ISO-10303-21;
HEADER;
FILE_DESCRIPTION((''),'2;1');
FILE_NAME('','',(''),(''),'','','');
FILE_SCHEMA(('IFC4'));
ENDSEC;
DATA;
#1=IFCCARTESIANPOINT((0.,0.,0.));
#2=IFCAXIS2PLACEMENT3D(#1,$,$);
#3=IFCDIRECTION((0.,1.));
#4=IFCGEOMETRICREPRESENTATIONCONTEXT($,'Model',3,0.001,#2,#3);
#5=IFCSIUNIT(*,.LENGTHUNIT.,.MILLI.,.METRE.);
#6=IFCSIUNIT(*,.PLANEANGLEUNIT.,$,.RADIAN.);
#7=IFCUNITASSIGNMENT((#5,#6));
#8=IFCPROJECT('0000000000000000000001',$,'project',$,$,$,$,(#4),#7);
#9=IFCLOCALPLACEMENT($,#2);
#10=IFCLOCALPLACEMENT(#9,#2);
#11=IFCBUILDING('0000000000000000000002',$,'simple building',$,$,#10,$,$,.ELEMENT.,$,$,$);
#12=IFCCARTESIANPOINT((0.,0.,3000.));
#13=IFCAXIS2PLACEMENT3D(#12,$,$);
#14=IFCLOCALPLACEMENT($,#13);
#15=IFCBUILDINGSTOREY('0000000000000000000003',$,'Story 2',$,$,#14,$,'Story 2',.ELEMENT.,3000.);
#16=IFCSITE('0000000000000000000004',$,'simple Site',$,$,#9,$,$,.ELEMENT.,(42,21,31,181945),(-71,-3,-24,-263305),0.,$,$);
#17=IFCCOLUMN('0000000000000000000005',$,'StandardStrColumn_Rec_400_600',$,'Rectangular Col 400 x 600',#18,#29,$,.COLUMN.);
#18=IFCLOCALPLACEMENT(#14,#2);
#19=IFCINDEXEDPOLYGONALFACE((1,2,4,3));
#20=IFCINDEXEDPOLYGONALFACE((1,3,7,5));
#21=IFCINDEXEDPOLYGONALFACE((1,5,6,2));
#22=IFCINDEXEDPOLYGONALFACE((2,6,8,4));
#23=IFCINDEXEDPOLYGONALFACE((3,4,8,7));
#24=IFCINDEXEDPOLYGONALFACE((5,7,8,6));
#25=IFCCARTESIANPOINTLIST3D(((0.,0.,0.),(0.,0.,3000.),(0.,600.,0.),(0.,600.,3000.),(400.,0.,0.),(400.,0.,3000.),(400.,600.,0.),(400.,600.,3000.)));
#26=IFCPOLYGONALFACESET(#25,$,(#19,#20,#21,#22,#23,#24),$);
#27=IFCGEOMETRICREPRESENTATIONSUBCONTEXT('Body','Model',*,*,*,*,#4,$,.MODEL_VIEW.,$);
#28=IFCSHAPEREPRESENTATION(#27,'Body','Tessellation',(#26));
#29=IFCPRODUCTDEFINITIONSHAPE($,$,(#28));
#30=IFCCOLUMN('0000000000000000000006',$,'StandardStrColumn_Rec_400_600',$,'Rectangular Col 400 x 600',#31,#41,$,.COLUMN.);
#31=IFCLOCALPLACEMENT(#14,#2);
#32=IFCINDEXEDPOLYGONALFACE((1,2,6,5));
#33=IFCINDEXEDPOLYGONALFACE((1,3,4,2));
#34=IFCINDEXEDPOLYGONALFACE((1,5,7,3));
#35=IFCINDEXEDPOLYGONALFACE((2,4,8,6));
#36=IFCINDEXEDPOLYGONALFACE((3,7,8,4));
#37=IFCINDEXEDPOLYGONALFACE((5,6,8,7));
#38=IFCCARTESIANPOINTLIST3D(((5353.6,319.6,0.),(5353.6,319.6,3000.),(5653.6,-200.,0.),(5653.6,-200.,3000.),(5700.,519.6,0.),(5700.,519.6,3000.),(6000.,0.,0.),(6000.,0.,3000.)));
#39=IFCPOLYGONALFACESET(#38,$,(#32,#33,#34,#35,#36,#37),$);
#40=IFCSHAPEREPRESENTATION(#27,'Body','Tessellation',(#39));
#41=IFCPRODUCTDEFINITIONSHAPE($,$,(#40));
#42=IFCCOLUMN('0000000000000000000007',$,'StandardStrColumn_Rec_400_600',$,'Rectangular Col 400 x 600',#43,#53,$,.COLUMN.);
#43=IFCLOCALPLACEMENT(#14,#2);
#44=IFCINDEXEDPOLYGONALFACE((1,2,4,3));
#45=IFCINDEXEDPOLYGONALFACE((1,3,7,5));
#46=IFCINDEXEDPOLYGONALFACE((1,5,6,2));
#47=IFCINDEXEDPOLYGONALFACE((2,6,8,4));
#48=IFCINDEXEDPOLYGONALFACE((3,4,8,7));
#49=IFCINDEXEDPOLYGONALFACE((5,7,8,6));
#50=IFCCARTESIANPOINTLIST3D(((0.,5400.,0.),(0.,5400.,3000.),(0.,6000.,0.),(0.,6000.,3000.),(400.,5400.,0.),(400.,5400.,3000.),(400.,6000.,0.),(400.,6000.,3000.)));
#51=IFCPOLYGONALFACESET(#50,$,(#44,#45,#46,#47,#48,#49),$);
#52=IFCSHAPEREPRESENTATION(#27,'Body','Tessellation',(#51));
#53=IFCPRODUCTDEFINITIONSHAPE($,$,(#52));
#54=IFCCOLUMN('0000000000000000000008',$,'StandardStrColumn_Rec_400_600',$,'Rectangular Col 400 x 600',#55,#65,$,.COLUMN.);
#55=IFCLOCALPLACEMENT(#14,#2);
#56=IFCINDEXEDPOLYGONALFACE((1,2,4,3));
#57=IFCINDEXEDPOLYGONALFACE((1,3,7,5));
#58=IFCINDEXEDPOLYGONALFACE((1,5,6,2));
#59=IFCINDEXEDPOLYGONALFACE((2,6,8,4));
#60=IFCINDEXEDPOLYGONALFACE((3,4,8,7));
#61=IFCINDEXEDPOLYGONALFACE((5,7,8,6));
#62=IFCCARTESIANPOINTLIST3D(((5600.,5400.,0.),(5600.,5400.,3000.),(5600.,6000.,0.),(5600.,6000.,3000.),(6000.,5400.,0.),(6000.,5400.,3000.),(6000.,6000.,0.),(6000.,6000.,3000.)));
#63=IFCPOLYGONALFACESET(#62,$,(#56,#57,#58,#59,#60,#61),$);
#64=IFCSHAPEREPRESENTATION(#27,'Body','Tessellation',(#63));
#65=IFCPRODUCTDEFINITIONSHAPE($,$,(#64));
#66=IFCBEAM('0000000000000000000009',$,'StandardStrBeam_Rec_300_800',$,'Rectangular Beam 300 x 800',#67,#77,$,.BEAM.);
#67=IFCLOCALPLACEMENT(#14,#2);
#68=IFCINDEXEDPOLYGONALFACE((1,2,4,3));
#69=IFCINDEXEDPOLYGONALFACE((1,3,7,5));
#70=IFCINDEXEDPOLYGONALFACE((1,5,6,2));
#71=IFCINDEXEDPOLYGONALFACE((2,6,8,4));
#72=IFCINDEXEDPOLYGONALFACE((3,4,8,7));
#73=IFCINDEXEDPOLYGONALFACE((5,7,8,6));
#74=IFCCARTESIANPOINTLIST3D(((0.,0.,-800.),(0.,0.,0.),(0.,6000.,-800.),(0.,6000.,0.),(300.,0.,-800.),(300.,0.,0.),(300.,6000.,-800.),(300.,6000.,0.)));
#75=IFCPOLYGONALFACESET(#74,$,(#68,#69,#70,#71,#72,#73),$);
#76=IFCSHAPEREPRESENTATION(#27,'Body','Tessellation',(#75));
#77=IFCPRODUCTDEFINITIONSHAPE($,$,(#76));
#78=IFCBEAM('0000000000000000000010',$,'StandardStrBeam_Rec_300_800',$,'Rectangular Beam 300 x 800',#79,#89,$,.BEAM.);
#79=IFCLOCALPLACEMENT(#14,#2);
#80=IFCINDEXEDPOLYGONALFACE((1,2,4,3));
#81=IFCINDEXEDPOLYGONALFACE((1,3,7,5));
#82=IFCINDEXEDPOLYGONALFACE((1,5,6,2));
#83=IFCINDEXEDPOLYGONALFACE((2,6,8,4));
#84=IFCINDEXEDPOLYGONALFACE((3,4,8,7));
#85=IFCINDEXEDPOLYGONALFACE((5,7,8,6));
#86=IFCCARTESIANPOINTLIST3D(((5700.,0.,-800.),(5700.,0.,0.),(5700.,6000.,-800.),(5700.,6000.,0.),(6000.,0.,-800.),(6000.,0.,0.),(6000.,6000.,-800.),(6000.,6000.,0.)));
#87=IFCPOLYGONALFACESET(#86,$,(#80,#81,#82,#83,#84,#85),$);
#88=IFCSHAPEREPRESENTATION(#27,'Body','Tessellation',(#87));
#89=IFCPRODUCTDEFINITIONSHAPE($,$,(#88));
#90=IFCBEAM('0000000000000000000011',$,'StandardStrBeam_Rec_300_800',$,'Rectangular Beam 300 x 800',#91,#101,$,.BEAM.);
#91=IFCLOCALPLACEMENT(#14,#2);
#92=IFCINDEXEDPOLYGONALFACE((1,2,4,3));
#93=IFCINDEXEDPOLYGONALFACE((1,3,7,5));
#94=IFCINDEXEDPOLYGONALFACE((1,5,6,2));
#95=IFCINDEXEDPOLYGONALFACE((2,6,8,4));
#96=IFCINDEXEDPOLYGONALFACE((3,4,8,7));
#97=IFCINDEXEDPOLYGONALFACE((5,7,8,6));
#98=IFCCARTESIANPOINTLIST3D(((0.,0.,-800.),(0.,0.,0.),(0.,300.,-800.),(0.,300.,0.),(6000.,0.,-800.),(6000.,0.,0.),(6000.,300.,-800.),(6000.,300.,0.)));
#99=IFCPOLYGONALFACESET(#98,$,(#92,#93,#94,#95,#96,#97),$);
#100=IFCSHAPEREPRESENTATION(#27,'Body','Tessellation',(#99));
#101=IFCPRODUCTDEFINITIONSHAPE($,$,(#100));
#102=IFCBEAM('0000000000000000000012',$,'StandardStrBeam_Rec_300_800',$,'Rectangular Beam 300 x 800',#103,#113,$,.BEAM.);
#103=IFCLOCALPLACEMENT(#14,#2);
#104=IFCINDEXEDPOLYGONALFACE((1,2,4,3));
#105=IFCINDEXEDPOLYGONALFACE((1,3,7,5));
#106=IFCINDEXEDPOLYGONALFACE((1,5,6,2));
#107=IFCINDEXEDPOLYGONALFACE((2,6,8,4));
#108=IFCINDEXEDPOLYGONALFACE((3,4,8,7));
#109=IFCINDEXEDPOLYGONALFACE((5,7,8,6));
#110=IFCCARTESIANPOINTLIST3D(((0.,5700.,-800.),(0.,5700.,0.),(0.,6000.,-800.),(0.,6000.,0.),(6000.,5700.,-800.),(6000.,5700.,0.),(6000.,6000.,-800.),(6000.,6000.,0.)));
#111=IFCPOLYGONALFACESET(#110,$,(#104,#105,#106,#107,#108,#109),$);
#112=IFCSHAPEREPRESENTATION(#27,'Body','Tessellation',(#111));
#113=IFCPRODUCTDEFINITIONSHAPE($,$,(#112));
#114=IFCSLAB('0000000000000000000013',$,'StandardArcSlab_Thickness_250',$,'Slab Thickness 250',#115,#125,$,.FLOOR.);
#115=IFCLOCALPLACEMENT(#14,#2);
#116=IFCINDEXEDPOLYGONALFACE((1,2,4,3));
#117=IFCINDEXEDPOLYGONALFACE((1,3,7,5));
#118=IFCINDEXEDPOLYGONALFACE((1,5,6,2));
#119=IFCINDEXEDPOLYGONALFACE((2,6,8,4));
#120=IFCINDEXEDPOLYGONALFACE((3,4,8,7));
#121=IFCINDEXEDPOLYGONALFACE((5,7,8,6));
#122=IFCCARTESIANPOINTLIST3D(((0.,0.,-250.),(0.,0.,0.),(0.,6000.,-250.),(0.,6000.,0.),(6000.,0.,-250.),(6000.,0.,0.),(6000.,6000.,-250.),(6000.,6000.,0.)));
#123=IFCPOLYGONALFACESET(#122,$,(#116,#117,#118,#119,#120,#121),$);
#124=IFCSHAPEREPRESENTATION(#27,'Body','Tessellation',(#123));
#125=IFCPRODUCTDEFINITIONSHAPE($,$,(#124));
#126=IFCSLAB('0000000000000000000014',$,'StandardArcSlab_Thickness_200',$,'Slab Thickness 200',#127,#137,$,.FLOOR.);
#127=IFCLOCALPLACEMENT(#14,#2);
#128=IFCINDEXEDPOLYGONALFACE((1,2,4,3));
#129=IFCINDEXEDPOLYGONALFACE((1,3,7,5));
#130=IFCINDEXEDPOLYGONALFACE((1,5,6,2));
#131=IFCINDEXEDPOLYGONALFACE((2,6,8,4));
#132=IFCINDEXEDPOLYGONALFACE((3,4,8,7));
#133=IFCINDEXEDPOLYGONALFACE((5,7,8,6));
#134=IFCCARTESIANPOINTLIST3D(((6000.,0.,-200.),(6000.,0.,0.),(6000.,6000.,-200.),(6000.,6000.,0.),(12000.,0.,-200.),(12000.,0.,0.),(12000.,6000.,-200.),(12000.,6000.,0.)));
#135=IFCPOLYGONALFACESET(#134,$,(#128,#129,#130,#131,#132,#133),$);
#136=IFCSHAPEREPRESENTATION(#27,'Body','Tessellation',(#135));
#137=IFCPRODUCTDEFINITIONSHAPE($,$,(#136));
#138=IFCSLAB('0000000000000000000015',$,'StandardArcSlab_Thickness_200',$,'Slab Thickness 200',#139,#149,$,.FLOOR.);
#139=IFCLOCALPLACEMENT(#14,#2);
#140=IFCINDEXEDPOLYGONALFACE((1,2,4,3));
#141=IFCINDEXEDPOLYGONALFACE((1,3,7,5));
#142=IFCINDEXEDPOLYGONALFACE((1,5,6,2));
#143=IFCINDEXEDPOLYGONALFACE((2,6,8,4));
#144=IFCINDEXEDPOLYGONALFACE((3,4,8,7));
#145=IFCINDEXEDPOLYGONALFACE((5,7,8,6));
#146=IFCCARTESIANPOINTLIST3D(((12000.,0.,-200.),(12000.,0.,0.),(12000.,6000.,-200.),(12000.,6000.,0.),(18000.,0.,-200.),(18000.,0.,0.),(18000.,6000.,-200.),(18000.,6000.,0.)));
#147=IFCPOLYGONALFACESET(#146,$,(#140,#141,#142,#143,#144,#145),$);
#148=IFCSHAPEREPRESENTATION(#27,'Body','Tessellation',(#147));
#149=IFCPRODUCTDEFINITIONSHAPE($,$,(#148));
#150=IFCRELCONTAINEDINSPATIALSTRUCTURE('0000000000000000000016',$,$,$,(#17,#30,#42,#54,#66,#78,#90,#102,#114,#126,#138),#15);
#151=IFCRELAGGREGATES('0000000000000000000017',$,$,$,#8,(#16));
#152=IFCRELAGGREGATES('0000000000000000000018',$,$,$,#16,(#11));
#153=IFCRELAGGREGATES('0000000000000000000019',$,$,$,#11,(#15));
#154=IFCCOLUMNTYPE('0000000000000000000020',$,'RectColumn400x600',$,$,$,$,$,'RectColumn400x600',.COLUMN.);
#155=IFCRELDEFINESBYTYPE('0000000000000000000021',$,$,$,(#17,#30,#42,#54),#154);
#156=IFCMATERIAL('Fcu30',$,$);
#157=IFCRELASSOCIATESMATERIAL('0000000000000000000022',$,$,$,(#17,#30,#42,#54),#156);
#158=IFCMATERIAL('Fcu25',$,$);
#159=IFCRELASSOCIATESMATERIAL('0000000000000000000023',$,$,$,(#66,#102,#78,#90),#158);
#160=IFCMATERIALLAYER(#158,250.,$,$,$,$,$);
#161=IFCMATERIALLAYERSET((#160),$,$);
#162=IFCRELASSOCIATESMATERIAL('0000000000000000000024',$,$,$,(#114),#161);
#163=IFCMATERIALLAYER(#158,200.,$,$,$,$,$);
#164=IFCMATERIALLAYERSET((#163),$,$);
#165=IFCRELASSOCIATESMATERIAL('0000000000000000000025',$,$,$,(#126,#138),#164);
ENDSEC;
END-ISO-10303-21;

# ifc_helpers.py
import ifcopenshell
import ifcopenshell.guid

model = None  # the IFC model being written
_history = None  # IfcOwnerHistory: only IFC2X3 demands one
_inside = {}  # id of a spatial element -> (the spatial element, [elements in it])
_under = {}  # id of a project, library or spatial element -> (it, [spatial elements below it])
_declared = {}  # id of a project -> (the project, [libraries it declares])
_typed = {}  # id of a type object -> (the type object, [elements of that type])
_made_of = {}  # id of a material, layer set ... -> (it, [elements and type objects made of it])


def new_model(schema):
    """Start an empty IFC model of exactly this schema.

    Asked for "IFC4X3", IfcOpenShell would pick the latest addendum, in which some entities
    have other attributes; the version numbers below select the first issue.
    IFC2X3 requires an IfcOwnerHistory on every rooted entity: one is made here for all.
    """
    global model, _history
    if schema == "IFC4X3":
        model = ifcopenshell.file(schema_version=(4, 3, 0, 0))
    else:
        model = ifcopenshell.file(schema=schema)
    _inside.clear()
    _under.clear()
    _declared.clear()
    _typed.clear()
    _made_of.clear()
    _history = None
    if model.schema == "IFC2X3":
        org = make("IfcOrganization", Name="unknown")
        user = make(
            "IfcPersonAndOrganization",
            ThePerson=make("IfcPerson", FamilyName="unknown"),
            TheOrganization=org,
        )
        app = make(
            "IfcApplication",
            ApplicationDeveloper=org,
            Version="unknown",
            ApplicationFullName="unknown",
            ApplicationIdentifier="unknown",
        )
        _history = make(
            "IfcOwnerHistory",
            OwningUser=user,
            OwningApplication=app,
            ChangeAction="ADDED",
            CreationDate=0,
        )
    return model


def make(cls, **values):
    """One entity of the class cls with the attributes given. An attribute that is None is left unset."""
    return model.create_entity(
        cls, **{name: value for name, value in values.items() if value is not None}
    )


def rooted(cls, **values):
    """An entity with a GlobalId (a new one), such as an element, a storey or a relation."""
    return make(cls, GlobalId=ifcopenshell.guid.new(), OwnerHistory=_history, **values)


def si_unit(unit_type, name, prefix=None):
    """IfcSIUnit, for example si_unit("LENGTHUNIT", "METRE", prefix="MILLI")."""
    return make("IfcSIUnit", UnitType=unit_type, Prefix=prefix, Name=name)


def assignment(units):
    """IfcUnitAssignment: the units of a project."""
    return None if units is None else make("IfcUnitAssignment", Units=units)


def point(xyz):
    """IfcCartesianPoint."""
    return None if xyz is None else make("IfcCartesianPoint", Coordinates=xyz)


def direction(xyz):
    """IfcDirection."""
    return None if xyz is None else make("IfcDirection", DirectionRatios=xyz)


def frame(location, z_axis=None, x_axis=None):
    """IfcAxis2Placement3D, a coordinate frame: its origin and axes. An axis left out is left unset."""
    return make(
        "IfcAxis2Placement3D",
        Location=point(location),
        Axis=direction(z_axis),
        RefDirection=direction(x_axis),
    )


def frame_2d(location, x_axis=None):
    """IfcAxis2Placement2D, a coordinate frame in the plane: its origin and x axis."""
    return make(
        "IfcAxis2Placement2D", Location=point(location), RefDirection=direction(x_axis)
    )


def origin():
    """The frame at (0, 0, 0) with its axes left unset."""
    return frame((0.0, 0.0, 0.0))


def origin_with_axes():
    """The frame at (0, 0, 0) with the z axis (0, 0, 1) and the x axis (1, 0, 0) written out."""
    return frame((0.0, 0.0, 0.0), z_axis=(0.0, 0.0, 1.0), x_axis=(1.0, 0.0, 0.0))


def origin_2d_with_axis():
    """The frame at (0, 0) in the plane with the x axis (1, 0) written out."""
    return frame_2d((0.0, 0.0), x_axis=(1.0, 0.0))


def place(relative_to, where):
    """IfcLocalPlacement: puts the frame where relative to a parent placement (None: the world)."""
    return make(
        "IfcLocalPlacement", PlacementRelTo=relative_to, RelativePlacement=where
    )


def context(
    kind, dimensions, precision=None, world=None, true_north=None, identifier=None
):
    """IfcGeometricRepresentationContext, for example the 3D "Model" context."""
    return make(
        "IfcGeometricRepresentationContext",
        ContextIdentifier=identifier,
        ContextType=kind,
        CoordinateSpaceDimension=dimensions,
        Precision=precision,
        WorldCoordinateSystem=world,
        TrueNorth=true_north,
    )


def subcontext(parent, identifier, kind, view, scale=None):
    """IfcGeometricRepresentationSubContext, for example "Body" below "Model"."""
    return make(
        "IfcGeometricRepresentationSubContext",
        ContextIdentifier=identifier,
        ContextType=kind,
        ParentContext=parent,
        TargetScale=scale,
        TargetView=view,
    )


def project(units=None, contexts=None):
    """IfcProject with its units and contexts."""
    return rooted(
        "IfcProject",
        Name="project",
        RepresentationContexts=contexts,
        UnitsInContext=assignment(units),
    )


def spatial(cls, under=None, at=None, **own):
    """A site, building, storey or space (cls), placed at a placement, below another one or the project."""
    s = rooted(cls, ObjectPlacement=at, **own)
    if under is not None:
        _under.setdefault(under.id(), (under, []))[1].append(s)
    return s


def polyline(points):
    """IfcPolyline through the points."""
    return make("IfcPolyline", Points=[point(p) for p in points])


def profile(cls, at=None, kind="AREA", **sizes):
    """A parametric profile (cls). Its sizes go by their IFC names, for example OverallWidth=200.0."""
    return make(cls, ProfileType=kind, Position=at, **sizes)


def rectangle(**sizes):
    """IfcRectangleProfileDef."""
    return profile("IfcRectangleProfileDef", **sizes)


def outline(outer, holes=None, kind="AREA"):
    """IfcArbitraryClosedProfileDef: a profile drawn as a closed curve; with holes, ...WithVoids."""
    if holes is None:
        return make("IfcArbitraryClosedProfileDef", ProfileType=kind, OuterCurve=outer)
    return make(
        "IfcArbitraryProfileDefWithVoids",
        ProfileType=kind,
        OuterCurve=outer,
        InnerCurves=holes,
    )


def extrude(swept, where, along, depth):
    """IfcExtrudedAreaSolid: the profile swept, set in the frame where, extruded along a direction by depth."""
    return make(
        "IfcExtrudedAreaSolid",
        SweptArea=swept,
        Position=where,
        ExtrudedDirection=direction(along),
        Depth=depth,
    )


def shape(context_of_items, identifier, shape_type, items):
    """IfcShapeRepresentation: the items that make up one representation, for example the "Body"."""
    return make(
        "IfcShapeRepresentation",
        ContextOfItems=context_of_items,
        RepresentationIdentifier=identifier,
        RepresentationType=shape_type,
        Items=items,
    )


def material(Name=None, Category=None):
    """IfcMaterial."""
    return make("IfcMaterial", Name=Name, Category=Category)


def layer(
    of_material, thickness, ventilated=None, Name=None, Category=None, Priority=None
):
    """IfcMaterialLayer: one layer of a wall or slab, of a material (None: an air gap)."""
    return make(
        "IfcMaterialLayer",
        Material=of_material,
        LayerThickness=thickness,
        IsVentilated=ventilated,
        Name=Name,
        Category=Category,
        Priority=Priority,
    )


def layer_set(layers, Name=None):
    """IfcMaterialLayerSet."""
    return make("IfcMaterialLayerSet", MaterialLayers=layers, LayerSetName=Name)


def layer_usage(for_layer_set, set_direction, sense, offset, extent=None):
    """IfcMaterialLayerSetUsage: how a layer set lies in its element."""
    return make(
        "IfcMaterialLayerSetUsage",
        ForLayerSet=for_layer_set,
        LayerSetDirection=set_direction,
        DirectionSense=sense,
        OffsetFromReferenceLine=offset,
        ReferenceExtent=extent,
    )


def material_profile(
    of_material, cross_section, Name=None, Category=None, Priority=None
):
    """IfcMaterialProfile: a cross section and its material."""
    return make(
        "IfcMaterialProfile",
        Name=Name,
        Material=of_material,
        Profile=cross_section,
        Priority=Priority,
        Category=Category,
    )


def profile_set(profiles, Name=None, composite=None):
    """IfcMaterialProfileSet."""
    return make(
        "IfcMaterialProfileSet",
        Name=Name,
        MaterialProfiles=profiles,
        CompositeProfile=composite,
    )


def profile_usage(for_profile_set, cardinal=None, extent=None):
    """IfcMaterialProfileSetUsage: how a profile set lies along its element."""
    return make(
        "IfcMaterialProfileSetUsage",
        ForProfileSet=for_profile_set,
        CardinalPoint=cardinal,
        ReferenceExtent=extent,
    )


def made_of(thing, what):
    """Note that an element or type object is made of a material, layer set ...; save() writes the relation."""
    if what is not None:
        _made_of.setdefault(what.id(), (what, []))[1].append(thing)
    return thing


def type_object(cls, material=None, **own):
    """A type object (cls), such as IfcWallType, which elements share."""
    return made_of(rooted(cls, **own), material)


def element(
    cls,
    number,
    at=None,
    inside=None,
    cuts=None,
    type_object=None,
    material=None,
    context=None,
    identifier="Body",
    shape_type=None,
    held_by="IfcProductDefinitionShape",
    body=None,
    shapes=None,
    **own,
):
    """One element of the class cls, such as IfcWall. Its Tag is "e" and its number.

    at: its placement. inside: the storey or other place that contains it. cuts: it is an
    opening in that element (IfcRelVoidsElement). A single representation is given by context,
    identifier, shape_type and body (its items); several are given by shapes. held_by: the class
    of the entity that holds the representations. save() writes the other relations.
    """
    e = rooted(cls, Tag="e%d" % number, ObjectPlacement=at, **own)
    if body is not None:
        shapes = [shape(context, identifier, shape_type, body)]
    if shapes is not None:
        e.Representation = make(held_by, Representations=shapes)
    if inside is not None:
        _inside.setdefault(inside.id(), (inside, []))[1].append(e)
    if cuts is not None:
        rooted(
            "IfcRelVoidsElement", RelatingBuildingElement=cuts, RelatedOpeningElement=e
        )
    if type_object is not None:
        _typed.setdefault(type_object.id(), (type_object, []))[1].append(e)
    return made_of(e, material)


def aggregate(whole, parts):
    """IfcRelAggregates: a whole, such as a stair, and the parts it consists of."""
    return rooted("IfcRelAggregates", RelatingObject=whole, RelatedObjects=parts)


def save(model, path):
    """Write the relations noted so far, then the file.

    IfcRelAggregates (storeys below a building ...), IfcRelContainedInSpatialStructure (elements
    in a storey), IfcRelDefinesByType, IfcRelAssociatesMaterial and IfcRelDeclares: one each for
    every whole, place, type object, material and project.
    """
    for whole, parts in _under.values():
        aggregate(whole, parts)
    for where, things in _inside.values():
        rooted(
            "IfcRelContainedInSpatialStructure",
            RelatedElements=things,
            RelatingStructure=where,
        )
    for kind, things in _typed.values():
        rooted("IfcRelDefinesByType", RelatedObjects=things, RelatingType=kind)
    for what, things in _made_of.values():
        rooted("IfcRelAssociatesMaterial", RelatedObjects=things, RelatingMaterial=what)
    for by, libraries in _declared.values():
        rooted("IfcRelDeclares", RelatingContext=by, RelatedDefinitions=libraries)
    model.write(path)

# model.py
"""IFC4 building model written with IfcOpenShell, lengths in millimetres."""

from ifc_helpers import new_model, si_unit, direction, frame, origin, origin_with_axes, origin_2d_with_axis, place, context, subcontext, project, spatial, polyline, rectangle, outline, extrude, material, layer, layer_set, layer_usage, material_profile, profile_set, profile_usage, type_object, element, save


model = new_model("IFC4")

# Units and contexts
model_context = context("Model", 3, precision=0.001, world=origin(), true_north=direction((0.0, 1.0)))
body_context = subcontext(model_context, "Body", "Model", "MODEL_VIEW")
ifc_project = project(units=[si_unit("LENGTHUNIT", "METRE", prefix="MILLI"), si_unit("PLANEANGLEUNIT", "RADIAN")], contexts=[model_context])

# Site, building, storey
site_placement = place(None, origin())
site = spatial("IfcSite", under=ifc_project, at=site_placement, Name="simple Site", CompositionType="ELEMENT", RefLatitude=(42, 21, 31, 181945), RefLongitude=(-71, -3, -24, -263305), RefElevation=0.0)
building_placement = place(site_placement, origin())
building = spatial("IfcBuilding", under=site, at=building_placement, Name="simple building", CompositionType="ELEMENT")
storey_placement = place(None, frame((0.0, 0.0, 3000.0)))
storey = spatial("IfcBuildingStorey", under=building, at=storey_placement, Name="Story 2", LongName="Story 2", CompositionType="ELEMENT", Elevation=3000.0)

# Columns
ifc_material_1 = material(Name="Fcu30")
ifc_material_profile_1 = material_profile(ifc_material_1, rectangle(XDim=400.0, YDim=600.0, at=origin_2d_with_axis()))
ifc_profile_set_1 = profile_set([ifc_material_profile_1])
ifc_profile_usage_1 = profile_usage(ifc_profile_set_1, cardinal=7)
column_type = type_object("IfcColumnType", Name="RectColumn400x600", ElementType="RectColumn400x600", PredefinedType="COLUMN")
column_1_placement = place(None, frame((200.0, 300.0, 3000.0), z_axis=(0.0, 0.0, 1.0), x_axis=(1.0, 0.0, 0.0)))
element("IfcColumn", 1, at=column_1_placement, inside=storey, type_object=column_type, material=ifc_profile_usage_1, Name="StandardStrColumn_Rec_400_600", ObjectType="Rectangular Col 400 x 600", PredefinedType="COLUMN", context=body_context, shape_type="SweptSolid", body=[
    extrude(rectangle(XDim=400.0, YDim=600.0, at=origin_2d_with_axis()), origin_with_axes(), (0.0, 0.0, 1.0), 3000.0),
])
ifc_profile_usage_2 = profile_usage(ifc_profile_set_1, cardinal=9)
column_2_placement = place(None, frame((5676.8, 159.8, 3000.0), z_axis=(0.0, 0.0, 1.0), x_axis=(0.866025, 0.5, 0.0)))
element("IfcColumn", 2, at=column_2_placement, inside=storey, type_object=column_type, material=ifc_profile_usage_2, Name="StandardStrColumn_Rec_400_600", ObjectType="Rectangular Col 400 x 600", PredefinedType="COLUMN", context=body_context, shape_type="SweptSolid", body=[
    extrude(rectangle(XDim=400.0, YDim=600.0, at=origin_2d_with_axis()), origin_with_axes(), (0.0, 0.0, 1.0), 3000.0),
])
ifc_profile_usage_3 = profile_usage(ifc_profile_set_1, cardinal=1)
column_3_placement = place(None, frame((200.0, 5700.0, 3000.0), z_axis=(0.0, 0.0, 1.0), x_axis=(1.0, 0.0, 0.0)))
element("IfcColumn", 3, at=column_3_placement, inside=storey, type_object=column_type, material=ifc_profile_usage_3, Name="StandardStrColumn_Rec_400_600", ObjectType="Rectangular Col 400 x 600", PredefinedType="COLUMN", context=body_context, shape_type="SweptSolid", body=[
    extrude(rectangle(XDim=400.0, YDim=600.0, at=origin_2d_with_axis()), origin_with_axes(), (0.0, 0.0, 1.0), 3000.0),
])
ifc_profile_usage_4 = profile_usage(ifc_profile_set_1, cardinal=3)
column_4_placement = place(None, frame((5800.0, 5700.0, 3000.0), z_axis=(0.0, 0.0, 1.0), x_axis=(1.0, 0.0, 0.0)))
element("IfcColumn", 4, at=column_4_placement, inside=storey, type_object=column_type, material=ifc_profile_usage_4, Name="StandardStrColumn_Rec_400_600", ObjectType="Rectangular Col 400 x 600", PredefinedType="COLUMN", context=body_context, shape_type="SweptSolid", body=[
    extrude(rectangle(XDim=400.0, YDim=600.0, at=origin_2d_with_axis()), origin_with_axes(), (0.0, 0.0, 1.0), 3000.0),
])

# Beams
ifc_material_2 = material(Name="Fcu25")
ifc_material_profile_2 = material_profile(ifc_material_2, rectangle(XDim=300.0, YDim=800.0, at=origin_2d_with_axis()))
ifc_profile_set_2 = profile_set([ifc_material_profile_2])
ifc_profile_usage_5 = profile_usage(ifc_profile_set_2, cardinal=7)
beam_1_placement = place(None, frame((150.0, 0.0, 2600.0), z_axis=(0.0, 1.0, 0.0), x_axis=(1.0, 0.0, 0.0)))
element("IfcBeam", 5, at=beam_1_placement, inside=storey, material=ifc_profile_usage_5, Name="StandardStrBeam_Rec_300_800", ObjectType="Rectangular Beam 300 x 800", PredefinedType="BEAM", context=body_context, shape_type="SweptSolid", body=[
    extrude(rectangle(XDim=300.0, YDim=800.0, at=origin_2d_with_axis()), origin_with_axes(), (0.0, 0.0, 1.0), 6000.0),
])
ifc_profile_usage_6 = profile_usage(ifc_profile_set_2, cardinal=9)
for number, where, z_axis, x_axis, name in (
    (6, (5850.0, 0.0, 2600.0), (0.0, 1.0, 0.0), (1.0, 0.0, 0.0), "StandardStrBeam_Rec_300_800"),
    (7, (0.0, 150.0, 2600.0), (1.0, 0.0, 0.0), (0.0, -1.0, 0.0), "StandardStrBeam_Rec_300_800"),
):
    element("IfcBeam", number, at=place(None, frame(where, z_axis=z_axis, x_axis=x_axis)), inside=storey, material=ifc_profile_usage_6, Name=name, ObjectType="Rectangular Beam 300 x 800", PredefinedType="BEAM", context=body_context, shape_type="SweptSolid", body=[
        extrude(rectangle(XDim=300.0, YDim=800.0, at=origin_2d_with_axis()), origin_with_axes(), (0.0, 0.0, 1.0), 6000.0),
    ])
beam_2_placement = place(None, frame((0.0, 5850.0, 2600.0), z_axis=(1.0, 0.0, 0.0), x_axis=(0.0, -1.0, 0.0)))
element("IfcBeam", 8, at=beam_2_placement, inside=storey, material=ifc_profile_usage_5, Name="StandardStrBeam_Rec_300_800", ObjectType="Rectangular Beam 300 x 800", PredefinedType="BEAM", context=body_context, shape_type="SweptSolid", body=[
    extrude(rectangle(XDim=300.0, YDim=800.0, at=origin_2d_with_axis()), origin_with_axes(), (0.0, 0.0, 1.0), 6000.0),
])

# Slabs
ifc_layer_1 = layer(ifc_material_2, 250.0)
ifc_layer_set_1 = layer_set([ifc_layer_1])
ifc_layer_usage_1 = layer_usage(ifc_layer_set_1, "AXIS3", "POSITIVE", -250.0)
slab_placement = place(None, frame((0.0, 0.0, 2750.0), z_axis=(0.0, 0.0, 1.0), x_axis=(1.0, 0.0, 0.0)))
element("IfcSlab", 9, at=slab_placement, inside=storey, material=ifc_layer_usage_1, Name="StandardArcSlab_Thickness_250", ObjectType="Slab Thickness 250", PredefinedType="FLOOR", context=body_context, shape_type="SweptSolid", body=[
    extrude(outline(polyline([(0.0, 0.0), (6000.0, 0.0), (6000.0, 6000.0), (0.0, 6000.0), (0.0, 0.0)])), origin_with_axes(), (0.0, 0.0, 1.0), 250.0),
])
ifc_layer_2 = layer(ifc_material_2, 200.0)
ifc_layer_set_2 = layer_set([ifc_layer_2])
ifc_layer_usage_2 = layer_usage(ifc_layer_set_2, "AXIS3", "POSITIVE", -200.0)
for number, where, z_axis, x_axis, name in (
    (10, (6000.0, 0.0, 2800.0), (0.0, 0.0, 1.0), (1.0, 0.0, 0.0), "StandardArcSlab_Thickness_200"),
    (11, (12000.0, 0.0, 2800.0), (0.0, 0.0, 1.0), (1.0, 0.0, 0.0), "StandardArcSlab_Thickness_200"),
):
    element("IfcSlab", number, at=place(None, frame(where, z_axis=z_axis, x_axis=x_axis)), inside=storey, material=ifc_layer_usage_2, Name=name, ObjectType="Slab Thickness 200", PredefinedType="FLOOR", context=body_context, shape_type="SweptSolid", body=[
        extrude(outline(polyline([(0.0, 0.0), (6000.0, 0.0), (6000.0, 6000.0), (0.0, 6000.0), (0.0, 0.0)])), origin_with_axes(), (0.0, 0.0, 1.0), 200.0),
    ])

save(model, "model.ifc")
